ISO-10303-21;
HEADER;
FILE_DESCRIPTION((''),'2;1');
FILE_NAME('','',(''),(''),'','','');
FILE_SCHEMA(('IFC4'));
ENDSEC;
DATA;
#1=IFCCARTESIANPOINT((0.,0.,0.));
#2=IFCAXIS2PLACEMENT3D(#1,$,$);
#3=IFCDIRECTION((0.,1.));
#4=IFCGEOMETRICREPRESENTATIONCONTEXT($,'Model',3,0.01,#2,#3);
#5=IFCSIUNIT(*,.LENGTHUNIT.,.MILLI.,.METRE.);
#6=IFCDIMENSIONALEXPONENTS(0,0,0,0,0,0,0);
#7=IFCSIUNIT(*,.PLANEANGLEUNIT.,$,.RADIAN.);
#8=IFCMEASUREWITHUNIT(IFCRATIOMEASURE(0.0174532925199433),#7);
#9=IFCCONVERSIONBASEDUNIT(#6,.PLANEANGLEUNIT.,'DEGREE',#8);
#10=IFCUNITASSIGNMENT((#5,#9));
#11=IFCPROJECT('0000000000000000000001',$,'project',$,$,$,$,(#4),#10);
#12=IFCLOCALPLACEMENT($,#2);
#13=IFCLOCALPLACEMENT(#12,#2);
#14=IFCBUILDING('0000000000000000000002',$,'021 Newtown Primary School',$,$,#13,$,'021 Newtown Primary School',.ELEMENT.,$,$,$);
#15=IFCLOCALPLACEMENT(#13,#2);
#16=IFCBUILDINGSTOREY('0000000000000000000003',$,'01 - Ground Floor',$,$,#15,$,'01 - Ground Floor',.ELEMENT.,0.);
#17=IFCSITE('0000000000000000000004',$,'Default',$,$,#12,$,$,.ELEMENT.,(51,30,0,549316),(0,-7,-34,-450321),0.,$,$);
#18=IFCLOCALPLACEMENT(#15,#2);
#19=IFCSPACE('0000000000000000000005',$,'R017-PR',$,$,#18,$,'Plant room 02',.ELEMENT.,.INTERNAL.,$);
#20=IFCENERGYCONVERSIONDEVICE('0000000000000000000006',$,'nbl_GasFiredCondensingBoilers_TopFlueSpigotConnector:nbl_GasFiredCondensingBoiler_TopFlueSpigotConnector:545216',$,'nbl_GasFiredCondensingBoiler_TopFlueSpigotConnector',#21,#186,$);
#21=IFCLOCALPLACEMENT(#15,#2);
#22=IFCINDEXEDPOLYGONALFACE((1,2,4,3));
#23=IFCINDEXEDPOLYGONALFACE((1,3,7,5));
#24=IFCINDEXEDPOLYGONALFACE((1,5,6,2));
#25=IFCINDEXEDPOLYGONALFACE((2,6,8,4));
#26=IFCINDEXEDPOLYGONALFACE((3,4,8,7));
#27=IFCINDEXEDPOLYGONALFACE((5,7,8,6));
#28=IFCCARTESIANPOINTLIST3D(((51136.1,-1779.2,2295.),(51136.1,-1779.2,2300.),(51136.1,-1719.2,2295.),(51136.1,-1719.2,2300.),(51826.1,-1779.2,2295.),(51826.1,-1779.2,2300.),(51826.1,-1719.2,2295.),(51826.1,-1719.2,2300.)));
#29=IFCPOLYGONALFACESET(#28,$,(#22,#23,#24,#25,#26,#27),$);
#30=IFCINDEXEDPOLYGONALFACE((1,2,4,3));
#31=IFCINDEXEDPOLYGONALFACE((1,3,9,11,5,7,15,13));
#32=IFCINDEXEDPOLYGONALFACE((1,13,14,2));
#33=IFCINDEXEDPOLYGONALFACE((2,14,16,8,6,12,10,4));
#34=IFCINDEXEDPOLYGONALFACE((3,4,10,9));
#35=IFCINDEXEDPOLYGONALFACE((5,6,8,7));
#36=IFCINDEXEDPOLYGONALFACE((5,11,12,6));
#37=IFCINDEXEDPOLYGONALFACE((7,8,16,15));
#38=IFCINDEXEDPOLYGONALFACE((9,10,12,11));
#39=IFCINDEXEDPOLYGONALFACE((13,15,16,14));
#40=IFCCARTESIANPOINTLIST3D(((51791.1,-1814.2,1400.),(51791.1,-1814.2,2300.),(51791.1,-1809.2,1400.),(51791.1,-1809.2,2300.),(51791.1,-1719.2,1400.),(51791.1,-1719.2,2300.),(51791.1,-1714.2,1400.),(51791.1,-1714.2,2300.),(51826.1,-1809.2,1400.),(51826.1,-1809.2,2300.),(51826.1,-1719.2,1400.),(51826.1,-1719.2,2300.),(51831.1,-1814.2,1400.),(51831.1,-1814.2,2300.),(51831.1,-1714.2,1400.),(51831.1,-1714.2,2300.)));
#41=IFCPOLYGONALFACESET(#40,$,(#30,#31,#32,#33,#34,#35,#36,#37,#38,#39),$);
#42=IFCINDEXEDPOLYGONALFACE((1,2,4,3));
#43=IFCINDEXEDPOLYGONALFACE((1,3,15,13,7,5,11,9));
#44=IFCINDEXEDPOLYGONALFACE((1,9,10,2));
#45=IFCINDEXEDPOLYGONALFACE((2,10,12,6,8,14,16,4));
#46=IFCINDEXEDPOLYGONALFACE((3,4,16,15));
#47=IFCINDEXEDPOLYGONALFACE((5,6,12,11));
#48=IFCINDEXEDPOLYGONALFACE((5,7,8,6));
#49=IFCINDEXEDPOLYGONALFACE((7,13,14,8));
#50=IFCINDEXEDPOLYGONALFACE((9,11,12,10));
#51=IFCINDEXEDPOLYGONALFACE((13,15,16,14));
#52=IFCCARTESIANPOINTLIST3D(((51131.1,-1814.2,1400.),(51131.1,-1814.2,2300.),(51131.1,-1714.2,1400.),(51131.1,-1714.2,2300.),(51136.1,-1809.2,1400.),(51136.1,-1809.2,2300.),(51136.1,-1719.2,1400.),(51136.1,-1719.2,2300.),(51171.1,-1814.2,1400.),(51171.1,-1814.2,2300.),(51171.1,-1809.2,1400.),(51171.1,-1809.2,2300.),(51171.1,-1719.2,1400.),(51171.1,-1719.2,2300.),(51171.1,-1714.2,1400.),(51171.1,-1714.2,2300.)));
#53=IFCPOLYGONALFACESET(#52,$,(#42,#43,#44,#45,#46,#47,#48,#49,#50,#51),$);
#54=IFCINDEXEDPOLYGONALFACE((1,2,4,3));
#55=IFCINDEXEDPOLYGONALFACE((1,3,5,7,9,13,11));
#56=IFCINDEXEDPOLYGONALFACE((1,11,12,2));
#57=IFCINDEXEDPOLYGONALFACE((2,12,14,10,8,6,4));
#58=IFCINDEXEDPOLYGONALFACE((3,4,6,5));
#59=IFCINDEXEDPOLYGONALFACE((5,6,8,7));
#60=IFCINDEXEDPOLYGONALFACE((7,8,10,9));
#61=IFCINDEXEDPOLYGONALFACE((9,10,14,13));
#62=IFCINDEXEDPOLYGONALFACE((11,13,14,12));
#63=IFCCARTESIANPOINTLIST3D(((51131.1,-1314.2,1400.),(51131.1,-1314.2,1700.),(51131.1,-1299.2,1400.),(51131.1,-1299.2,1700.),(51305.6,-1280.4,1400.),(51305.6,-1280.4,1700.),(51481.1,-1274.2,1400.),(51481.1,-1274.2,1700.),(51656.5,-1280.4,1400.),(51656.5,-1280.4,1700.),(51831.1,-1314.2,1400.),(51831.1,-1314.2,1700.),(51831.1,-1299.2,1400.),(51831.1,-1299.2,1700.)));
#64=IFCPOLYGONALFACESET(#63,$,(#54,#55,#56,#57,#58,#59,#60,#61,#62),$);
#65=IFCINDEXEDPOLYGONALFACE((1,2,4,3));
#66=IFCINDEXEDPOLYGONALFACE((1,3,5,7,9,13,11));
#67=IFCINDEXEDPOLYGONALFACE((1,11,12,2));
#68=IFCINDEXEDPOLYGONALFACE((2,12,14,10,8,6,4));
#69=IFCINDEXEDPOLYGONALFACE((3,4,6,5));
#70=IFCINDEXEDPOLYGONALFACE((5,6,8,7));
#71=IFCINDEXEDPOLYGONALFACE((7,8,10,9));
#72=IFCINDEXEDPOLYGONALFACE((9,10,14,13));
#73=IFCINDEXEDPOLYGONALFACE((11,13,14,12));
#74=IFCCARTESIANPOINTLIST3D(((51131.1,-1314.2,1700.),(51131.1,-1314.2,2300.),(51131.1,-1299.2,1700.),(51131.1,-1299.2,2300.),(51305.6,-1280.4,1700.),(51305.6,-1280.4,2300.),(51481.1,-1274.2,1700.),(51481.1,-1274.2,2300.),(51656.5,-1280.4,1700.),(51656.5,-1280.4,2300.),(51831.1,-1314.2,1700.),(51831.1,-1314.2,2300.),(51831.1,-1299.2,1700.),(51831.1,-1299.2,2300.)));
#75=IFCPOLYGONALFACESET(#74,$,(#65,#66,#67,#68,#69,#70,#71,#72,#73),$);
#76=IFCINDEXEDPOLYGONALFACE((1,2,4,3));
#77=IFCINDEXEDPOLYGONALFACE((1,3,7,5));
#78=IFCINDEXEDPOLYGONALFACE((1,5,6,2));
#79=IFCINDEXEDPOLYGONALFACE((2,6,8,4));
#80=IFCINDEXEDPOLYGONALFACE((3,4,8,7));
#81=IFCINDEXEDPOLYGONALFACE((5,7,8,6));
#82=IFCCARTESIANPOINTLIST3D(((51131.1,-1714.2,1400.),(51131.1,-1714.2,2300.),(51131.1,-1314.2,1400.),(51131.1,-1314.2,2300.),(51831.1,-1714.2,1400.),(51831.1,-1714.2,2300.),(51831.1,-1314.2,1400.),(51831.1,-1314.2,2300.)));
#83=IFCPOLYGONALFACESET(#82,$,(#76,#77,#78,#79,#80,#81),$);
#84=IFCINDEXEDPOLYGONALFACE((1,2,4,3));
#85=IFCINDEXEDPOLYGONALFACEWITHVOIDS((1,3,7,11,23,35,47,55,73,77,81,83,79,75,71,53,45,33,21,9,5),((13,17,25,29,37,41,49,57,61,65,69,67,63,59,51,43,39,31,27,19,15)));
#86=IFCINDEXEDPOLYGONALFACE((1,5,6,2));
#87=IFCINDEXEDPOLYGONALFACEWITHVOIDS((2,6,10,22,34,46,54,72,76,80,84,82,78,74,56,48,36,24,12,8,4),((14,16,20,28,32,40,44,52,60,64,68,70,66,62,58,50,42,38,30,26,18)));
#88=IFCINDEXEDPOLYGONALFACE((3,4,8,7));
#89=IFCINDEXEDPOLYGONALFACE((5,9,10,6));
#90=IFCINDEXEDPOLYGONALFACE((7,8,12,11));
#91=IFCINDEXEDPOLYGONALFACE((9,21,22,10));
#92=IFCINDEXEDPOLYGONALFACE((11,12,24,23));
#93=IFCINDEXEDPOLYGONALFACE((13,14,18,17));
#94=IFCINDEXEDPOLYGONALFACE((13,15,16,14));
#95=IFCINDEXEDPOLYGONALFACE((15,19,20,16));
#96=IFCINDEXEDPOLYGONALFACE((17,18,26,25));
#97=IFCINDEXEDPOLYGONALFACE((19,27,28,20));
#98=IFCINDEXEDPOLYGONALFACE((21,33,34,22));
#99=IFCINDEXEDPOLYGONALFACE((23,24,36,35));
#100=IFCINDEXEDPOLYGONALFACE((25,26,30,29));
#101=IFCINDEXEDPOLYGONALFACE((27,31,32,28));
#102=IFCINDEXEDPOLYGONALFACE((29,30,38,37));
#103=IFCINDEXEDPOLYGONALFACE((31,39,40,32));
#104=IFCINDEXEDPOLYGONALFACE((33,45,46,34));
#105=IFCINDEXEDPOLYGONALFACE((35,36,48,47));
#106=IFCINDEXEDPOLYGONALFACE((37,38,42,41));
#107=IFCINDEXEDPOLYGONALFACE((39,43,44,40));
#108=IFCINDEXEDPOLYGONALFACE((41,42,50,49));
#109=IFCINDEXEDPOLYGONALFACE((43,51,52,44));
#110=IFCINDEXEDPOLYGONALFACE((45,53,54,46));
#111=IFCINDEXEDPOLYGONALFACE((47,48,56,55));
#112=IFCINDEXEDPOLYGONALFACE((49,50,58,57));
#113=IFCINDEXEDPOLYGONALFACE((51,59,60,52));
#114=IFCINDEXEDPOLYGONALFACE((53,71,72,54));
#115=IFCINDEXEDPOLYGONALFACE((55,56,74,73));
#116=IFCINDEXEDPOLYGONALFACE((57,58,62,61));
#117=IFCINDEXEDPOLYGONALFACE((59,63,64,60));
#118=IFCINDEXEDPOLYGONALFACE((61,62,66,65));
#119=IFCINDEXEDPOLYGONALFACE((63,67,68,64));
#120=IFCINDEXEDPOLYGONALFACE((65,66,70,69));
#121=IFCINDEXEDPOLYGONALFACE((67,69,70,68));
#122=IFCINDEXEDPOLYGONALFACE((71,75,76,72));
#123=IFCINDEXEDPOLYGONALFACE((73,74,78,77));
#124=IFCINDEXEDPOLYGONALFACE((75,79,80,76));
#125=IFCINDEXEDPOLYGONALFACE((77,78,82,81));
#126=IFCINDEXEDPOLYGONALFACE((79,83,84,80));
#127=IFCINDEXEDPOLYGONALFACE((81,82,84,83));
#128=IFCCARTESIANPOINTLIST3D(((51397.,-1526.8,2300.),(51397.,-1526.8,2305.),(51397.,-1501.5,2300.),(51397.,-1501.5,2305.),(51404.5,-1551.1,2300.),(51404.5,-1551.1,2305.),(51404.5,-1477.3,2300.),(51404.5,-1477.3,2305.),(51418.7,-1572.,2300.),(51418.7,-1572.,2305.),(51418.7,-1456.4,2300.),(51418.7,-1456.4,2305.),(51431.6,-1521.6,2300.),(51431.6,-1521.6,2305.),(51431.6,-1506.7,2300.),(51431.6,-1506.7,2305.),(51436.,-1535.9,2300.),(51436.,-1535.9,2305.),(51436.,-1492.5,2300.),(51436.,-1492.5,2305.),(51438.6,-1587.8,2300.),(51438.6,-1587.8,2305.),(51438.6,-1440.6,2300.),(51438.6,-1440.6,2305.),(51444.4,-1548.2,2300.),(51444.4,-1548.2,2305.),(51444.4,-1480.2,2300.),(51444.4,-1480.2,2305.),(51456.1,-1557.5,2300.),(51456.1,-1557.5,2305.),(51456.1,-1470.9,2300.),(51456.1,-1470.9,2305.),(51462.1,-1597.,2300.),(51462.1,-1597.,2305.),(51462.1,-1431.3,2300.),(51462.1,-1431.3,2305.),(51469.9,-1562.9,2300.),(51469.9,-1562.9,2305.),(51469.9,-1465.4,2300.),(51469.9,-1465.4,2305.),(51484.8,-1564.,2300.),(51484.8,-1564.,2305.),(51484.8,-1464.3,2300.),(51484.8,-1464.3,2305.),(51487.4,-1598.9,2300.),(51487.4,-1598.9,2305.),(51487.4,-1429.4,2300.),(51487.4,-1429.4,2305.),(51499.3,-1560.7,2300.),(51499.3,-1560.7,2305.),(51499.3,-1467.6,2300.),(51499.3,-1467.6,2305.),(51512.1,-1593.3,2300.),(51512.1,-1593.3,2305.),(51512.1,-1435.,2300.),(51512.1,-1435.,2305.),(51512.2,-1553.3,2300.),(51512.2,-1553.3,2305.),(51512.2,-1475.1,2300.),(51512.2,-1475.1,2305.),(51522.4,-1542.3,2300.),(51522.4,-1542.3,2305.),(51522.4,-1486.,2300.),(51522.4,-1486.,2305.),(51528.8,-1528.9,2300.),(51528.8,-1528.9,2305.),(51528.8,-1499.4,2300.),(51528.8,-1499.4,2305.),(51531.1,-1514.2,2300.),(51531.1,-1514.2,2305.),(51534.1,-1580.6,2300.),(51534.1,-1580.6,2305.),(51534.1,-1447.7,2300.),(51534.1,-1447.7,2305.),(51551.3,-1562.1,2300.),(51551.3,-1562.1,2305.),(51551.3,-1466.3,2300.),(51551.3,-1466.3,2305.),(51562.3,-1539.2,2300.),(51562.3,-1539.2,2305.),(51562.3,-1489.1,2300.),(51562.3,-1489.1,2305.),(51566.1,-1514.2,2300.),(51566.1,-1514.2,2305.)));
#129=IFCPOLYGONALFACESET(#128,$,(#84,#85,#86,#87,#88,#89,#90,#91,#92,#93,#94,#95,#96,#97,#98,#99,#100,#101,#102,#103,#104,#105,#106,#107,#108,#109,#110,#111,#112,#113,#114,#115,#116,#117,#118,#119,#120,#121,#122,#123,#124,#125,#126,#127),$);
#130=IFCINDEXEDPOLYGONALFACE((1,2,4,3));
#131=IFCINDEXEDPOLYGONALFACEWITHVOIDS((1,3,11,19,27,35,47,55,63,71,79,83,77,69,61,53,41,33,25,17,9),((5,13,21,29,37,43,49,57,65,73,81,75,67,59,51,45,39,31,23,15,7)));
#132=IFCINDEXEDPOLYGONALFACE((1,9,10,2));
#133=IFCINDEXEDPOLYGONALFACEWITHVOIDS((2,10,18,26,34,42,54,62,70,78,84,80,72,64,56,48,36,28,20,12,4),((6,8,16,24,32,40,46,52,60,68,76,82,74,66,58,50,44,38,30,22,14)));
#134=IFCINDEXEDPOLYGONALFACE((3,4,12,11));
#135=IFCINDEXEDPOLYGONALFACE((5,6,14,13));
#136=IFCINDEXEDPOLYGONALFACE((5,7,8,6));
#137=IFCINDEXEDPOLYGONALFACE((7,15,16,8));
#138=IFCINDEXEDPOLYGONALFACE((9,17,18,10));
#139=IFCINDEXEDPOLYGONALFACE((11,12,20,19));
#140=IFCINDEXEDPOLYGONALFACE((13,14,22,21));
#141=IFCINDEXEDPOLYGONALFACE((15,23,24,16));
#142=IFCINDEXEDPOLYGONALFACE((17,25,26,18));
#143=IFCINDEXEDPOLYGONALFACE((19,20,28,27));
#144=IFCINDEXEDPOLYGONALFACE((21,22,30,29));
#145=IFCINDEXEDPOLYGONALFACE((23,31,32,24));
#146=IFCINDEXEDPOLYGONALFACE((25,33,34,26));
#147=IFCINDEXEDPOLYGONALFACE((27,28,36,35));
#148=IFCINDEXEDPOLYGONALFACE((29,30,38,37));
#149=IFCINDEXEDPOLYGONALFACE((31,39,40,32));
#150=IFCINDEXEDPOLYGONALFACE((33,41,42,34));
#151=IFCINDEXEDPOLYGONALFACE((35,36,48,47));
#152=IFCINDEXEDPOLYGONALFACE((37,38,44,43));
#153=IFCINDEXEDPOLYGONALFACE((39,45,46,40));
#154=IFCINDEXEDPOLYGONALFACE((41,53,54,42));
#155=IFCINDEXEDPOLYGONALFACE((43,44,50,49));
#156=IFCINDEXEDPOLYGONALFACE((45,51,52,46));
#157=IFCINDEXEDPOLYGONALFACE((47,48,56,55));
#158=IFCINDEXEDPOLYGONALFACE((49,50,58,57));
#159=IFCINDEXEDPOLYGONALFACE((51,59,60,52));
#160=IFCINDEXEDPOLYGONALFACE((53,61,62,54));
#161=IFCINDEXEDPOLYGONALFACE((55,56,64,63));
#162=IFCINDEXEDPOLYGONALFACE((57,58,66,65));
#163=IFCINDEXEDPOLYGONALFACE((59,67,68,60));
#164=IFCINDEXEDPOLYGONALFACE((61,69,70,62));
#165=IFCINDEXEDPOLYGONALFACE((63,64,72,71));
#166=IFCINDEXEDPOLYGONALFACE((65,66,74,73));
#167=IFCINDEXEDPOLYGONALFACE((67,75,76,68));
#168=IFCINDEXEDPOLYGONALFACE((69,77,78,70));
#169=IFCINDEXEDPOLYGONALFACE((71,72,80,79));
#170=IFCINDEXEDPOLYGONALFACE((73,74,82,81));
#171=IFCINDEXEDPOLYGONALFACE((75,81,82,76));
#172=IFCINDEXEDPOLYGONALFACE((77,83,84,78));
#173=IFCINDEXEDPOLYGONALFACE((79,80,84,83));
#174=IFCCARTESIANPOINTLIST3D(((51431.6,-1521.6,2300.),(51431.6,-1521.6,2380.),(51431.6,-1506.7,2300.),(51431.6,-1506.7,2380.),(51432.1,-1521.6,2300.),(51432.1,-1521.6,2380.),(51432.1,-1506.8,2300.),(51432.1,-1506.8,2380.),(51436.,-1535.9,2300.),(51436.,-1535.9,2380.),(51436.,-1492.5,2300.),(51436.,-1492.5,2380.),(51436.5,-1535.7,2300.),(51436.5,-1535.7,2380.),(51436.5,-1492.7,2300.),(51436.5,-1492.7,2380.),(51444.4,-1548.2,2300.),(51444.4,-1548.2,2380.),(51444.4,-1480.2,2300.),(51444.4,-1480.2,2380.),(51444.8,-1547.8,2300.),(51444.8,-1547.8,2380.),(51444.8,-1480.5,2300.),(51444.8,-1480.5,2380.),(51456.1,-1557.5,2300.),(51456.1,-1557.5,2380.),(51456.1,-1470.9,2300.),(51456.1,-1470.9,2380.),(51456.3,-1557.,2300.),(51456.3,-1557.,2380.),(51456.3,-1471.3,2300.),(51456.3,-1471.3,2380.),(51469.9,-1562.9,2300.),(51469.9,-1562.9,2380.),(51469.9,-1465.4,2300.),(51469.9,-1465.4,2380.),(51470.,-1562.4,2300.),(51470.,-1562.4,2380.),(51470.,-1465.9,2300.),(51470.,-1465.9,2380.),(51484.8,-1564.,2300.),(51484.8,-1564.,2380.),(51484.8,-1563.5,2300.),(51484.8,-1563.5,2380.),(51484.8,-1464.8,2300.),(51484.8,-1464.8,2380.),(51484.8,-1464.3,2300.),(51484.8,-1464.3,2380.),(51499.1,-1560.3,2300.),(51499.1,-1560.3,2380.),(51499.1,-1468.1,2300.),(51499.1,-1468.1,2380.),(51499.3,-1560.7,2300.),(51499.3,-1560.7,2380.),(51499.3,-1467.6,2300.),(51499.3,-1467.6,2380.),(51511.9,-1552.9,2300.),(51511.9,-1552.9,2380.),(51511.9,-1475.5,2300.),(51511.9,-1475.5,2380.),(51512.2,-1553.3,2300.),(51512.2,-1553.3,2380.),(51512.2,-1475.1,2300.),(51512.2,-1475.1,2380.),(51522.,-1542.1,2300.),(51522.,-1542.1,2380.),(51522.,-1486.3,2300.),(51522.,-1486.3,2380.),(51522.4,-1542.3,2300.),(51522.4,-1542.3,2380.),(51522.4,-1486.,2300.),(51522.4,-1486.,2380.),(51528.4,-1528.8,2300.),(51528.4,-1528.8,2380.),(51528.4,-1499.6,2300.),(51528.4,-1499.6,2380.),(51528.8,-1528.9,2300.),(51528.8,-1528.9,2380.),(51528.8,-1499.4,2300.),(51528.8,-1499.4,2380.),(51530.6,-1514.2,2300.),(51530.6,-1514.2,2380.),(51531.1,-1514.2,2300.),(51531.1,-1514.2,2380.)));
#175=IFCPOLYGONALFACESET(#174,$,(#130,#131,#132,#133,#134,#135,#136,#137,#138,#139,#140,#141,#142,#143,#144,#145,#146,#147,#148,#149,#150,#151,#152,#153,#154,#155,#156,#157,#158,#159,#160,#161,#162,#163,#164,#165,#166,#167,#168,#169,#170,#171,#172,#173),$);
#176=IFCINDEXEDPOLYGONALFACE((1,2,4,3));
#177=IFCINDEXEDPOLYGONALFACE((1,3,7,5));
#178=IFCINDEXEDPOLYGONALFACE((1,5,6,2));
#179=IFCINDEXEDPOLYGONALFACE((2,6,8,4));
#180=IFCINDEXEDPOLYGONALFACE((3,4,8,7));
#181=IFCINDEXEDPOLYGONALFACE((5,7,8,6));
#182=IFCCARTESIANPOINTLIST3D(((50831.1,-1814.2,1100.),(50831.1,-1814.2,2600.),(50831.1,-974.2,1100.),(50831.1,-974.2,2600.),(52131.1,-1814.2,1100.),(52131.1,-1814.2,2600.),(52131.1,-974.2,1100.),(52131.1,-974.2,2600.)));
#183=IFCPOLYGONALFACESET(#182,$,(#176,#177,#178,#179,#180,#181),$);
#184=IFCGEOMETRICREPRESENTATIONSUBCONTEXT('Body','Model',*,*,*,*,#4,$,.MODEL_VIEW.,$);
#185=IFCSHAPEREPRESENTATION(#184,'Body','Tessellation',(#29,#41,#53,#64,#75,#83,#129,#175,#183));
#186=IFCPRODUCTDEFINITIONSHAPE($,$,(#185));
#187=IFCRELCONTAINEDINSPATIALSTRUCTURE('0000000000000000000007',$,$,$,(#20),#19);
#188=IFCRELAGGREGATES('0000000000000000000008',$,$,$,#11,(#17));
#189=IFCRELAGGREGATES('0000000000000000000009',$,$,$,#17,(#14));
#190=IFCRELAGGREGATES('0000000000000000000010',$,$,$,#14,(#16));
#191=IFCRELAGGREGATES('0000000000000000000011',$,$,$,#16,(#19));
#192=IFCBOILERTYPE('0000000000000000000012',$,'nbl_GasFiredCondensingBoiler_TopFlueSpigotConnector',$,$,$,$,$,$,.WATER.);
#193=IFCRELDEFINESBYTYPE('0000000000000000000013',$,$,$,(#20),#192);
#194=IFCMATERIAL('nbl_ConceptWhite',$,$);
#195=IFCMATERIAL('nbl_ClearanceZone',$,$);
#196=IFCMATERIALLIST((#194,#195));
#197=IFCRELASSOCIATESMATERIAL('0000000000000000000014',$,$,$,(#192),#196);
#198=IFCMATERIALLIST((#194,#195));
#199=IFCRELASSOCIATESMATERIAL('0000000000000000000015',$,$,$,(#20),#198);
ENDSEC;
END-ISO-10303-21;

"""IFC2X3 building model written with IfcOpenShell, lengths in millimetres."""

from ifc_helpers import new_model, entity, si_unit, converted_unit, direction, frame, frame_2d, origin, origin_2d_with_axis, place, context, subcontext, project, spatial, polyline, circle_curve, parameter, trimmed, segment, composite_curve, rectangle, hollow_circle, outline, extrude, source, transform, mapped, material, material_list, type_object, type_shapes, element, save


model = new_model("IFC2X3")

# Units and contexts
model_context = context("Model", 3, precision=0.01, world=origin(), true_north=direction((0.0, 1.0)))
body_context = subcontext(model_context, "Body", "Model", "MODEL_VIEW")
ifc_project = project(units=[si_unit("LENGTHUNIT", "METRE", prefix="MILLI"), converted_unit("PLANEANGLEUNIT", "DEGREE", entity("IfcRatioMeasure", 0.0174532925199433), si_unit("PLANEANGLEUNIT", "RADIAN"), dimensions=[0, 0, 0, 0, 0, 0, 0])], contexts=[model_context])

# Site, building, storey
site_placement = place(None, origin())
site = spatial("IfcSite", under=ifc_project, at=site_placement, Name="Default", CompositionType="ELEMENT", RefLatitude=(51, 30, 0, 549316), RefLongitude=(0, -7, -34, -450321), RefElevation=0.0)
building_placement = place(site_placement, origin())
building = spatial("IfcBuilding", under=site, at=building_placement, Name="021 Newtown Primary School", LongName="021 Newtown Primary School", CompositionType="ELEMENT")
storey_placement = place(building_placement, origin())
storey = spatial("IfcBuildingStorey", under=building, at=storey_placement, Name="01 - Ground Floor", LongName="01 - Ground Floor", CompositionType="ELEMENT", Elevation=0.0)

# Shared definitions
space_placement = place(storey_placement, origin())
space = spatial("IfcSpace", under=storey, at=space_placement, Name="R017-PR", LongName="Plant room 02", CompositionType="ELEMENT", InteriorOrExteriorSpace="INTERNAL")

# Energy conversion device
ifc_material_1 = material(Name="nbl_ConceptWhite")
ifc_material_2 = material(Name="nbl_ClearanceZone")
ifc_material_list_1 = material_list([ifc_material_1, ifc_material_2])
ifc_material_list_2 = material_list([ifc_material_1, ifc_material_2])
boiler_type = type_object("IfcBoilerType", Name="nbl_GasFiredCondensingBoiler_TopFlueSpigotConnector", PredefinedType="WATER", material=ifc_material_list_2)
shared_shape = source(origin(), body_context, "Body", "SweptSolid", [
    extrude(rectangle(XDim=690.0, YDim=60.0, at=origin_2d_with_axis()), frame((0.0, 65.0, 895.0), z_axis=(0.0, 0.0, 1.0), x_axis=(-1.0, 0.0, 0.0)), (0.0, 0.0, 1.0), 5.0),
    extrude(outline(polyline([(-21.2, -50.0), (18.8, -50.0), (18.8, -45.0), (-16.2, -45.0), (-16.3, 45.0), (18.7, 45.0), (18.7, 50.0), (-21.2, 50.0), (-21.2, -50.0)])), frame((328.7, 50.0, 0.0), z_axis=(0.0, 0.0, 1.0), x_axis=(-1.0, 0.0, 0.0)), (0.0, 0.0, 1.0), 900.0),
    extrude(outline(polyline([(-50.0, -21.3), (50.0, -21.3), (50.0, 18.8), (45.0, 18.8), (45.0, -16.2), (-45.0, -16.3), (-45.0, 18.7), (-50.0, 18.7), (-50.0, -21.3)])), frame((-328.8, 50.0, 0.0), z_axis=(0.0, 0.0, 1.0), x_axis=(0.0, -1.0, 0.0)), (0.0, 0.0, 1.0), 900.0),
    extrude(outline(composite_curve([segment(polyline([(-7.5, -350.0), (7.5, -350.0)]), True, "CONTINUOUS"), segment(trimmed(circle_curve(frame_2d((-2430.0, 0.0), x_axis=(0.0, -1.0)), 2462.5), [parameter(81.828766)], [parameter(98.171234)], True, "PARAMETER"), True, "CONTINUOUS"), segment(polyline([(7.5, 350.0), (-7.5, 350.0)]), True, "CONTINUOUS"), segment(polyline([(-7.5, 350.0), (-7.5, -350.0)]), True, "CONTINUOUS")], self_intersect=False)), frame((0.0, 507.5, 0.0), z_axis=(0.0, 0.0, 1.0), x_axis=(0.0, 1.0, 0.0)), (0.0, 0.0, 1.0), 300.0),
    extrude(outline(composite_curve([segment(polyline([(-350.0, -7.5), (350.0, -7.5)]), True, "CONTINUOUS"), segment(polyline([(350.0, -7.5), (350.0, 7.5)]), True, "CONTINUOUS"), segment(trimmed(circle_curve(frame_2d((0.0, -2430.0), x_axis=(1.0, 0.0)), 2462.5), [parameter(81.828766)], [parameter(98.171234)], True, "PARAMETER"), True, "CONTINUOUS"), segment(polyline([(-350.0, 7.5), (-350.0, -7.5)]), True, "CONTINUOUS")], self_intersect=False)), frame((0.0, 507.5, 300.0)), (0.0, 0.0, 1.0), 600.0),
    extrude(rectangle(XDim=700.0, YDim=400.0, at=origin_2d_with_axis()), frame((0.0, 300.0, 0.0), z_axis=(0.0, 0.0, 1.0), x_axis=(-1.0, 0.0, 0.0)), (0.0, 0.0, 1.0), 900.0),
    extrude(hollow_circle(Radius=85.0, WallThickness=35.0, at=frame_2d((0.0, 0.0), x_axis=(1.0, 0.0))), frame((0.0, 300.0, 900.0)), (0.0, 0.0, 1.0), 5.0),
    extrude(hollow_circle(Radius=50.0, WallThickness=0.5, at=frame_2d((0.0, 0.0), x_axis=(1.0, 0.0))), frame((0.0, 300.0, 900.0)), (0.0, 0.0, 1.0), 80.0),
    extrude(rectangle(XDim=840.0, YDim=1300.0, at=origin_2d_with_axis()), frame((0.0, 420.0, -300.0), z_axis=(0.0, 0.0, 1.0), x_axis=(0.0, 1.0, 0.0)), (0.0, 0.0, 1.0), 1500.0),
])
type_shapes(boiler_type, [shared_shape])
energy_conversion_device_1_placement = place(space_placement, frame((51481.1, -1814.2, 1400.0)))
element("IfcEnergyConversionDevice", 1, at=energy_conversion_device_1_placement, inside=space, type_object=boiler_type, material=ifc_material_list_1, Name="nbl_GasFiredCondensingBoilers_TopFlueSpigotConnector:nbl_GasFiredCondensingBoiler_TopFlueSpigotConnector:545216", ObjectType="nbl_GasFiredCondensingBoiler_TopFlueSpigotConnector", context=body_context, shape_type="MappedRepresentation", body=[
    mapped(shared_shape, transform((0.0, 0.0, 0.0), scale=1.0)),
])

save(model, "model.ifc")
